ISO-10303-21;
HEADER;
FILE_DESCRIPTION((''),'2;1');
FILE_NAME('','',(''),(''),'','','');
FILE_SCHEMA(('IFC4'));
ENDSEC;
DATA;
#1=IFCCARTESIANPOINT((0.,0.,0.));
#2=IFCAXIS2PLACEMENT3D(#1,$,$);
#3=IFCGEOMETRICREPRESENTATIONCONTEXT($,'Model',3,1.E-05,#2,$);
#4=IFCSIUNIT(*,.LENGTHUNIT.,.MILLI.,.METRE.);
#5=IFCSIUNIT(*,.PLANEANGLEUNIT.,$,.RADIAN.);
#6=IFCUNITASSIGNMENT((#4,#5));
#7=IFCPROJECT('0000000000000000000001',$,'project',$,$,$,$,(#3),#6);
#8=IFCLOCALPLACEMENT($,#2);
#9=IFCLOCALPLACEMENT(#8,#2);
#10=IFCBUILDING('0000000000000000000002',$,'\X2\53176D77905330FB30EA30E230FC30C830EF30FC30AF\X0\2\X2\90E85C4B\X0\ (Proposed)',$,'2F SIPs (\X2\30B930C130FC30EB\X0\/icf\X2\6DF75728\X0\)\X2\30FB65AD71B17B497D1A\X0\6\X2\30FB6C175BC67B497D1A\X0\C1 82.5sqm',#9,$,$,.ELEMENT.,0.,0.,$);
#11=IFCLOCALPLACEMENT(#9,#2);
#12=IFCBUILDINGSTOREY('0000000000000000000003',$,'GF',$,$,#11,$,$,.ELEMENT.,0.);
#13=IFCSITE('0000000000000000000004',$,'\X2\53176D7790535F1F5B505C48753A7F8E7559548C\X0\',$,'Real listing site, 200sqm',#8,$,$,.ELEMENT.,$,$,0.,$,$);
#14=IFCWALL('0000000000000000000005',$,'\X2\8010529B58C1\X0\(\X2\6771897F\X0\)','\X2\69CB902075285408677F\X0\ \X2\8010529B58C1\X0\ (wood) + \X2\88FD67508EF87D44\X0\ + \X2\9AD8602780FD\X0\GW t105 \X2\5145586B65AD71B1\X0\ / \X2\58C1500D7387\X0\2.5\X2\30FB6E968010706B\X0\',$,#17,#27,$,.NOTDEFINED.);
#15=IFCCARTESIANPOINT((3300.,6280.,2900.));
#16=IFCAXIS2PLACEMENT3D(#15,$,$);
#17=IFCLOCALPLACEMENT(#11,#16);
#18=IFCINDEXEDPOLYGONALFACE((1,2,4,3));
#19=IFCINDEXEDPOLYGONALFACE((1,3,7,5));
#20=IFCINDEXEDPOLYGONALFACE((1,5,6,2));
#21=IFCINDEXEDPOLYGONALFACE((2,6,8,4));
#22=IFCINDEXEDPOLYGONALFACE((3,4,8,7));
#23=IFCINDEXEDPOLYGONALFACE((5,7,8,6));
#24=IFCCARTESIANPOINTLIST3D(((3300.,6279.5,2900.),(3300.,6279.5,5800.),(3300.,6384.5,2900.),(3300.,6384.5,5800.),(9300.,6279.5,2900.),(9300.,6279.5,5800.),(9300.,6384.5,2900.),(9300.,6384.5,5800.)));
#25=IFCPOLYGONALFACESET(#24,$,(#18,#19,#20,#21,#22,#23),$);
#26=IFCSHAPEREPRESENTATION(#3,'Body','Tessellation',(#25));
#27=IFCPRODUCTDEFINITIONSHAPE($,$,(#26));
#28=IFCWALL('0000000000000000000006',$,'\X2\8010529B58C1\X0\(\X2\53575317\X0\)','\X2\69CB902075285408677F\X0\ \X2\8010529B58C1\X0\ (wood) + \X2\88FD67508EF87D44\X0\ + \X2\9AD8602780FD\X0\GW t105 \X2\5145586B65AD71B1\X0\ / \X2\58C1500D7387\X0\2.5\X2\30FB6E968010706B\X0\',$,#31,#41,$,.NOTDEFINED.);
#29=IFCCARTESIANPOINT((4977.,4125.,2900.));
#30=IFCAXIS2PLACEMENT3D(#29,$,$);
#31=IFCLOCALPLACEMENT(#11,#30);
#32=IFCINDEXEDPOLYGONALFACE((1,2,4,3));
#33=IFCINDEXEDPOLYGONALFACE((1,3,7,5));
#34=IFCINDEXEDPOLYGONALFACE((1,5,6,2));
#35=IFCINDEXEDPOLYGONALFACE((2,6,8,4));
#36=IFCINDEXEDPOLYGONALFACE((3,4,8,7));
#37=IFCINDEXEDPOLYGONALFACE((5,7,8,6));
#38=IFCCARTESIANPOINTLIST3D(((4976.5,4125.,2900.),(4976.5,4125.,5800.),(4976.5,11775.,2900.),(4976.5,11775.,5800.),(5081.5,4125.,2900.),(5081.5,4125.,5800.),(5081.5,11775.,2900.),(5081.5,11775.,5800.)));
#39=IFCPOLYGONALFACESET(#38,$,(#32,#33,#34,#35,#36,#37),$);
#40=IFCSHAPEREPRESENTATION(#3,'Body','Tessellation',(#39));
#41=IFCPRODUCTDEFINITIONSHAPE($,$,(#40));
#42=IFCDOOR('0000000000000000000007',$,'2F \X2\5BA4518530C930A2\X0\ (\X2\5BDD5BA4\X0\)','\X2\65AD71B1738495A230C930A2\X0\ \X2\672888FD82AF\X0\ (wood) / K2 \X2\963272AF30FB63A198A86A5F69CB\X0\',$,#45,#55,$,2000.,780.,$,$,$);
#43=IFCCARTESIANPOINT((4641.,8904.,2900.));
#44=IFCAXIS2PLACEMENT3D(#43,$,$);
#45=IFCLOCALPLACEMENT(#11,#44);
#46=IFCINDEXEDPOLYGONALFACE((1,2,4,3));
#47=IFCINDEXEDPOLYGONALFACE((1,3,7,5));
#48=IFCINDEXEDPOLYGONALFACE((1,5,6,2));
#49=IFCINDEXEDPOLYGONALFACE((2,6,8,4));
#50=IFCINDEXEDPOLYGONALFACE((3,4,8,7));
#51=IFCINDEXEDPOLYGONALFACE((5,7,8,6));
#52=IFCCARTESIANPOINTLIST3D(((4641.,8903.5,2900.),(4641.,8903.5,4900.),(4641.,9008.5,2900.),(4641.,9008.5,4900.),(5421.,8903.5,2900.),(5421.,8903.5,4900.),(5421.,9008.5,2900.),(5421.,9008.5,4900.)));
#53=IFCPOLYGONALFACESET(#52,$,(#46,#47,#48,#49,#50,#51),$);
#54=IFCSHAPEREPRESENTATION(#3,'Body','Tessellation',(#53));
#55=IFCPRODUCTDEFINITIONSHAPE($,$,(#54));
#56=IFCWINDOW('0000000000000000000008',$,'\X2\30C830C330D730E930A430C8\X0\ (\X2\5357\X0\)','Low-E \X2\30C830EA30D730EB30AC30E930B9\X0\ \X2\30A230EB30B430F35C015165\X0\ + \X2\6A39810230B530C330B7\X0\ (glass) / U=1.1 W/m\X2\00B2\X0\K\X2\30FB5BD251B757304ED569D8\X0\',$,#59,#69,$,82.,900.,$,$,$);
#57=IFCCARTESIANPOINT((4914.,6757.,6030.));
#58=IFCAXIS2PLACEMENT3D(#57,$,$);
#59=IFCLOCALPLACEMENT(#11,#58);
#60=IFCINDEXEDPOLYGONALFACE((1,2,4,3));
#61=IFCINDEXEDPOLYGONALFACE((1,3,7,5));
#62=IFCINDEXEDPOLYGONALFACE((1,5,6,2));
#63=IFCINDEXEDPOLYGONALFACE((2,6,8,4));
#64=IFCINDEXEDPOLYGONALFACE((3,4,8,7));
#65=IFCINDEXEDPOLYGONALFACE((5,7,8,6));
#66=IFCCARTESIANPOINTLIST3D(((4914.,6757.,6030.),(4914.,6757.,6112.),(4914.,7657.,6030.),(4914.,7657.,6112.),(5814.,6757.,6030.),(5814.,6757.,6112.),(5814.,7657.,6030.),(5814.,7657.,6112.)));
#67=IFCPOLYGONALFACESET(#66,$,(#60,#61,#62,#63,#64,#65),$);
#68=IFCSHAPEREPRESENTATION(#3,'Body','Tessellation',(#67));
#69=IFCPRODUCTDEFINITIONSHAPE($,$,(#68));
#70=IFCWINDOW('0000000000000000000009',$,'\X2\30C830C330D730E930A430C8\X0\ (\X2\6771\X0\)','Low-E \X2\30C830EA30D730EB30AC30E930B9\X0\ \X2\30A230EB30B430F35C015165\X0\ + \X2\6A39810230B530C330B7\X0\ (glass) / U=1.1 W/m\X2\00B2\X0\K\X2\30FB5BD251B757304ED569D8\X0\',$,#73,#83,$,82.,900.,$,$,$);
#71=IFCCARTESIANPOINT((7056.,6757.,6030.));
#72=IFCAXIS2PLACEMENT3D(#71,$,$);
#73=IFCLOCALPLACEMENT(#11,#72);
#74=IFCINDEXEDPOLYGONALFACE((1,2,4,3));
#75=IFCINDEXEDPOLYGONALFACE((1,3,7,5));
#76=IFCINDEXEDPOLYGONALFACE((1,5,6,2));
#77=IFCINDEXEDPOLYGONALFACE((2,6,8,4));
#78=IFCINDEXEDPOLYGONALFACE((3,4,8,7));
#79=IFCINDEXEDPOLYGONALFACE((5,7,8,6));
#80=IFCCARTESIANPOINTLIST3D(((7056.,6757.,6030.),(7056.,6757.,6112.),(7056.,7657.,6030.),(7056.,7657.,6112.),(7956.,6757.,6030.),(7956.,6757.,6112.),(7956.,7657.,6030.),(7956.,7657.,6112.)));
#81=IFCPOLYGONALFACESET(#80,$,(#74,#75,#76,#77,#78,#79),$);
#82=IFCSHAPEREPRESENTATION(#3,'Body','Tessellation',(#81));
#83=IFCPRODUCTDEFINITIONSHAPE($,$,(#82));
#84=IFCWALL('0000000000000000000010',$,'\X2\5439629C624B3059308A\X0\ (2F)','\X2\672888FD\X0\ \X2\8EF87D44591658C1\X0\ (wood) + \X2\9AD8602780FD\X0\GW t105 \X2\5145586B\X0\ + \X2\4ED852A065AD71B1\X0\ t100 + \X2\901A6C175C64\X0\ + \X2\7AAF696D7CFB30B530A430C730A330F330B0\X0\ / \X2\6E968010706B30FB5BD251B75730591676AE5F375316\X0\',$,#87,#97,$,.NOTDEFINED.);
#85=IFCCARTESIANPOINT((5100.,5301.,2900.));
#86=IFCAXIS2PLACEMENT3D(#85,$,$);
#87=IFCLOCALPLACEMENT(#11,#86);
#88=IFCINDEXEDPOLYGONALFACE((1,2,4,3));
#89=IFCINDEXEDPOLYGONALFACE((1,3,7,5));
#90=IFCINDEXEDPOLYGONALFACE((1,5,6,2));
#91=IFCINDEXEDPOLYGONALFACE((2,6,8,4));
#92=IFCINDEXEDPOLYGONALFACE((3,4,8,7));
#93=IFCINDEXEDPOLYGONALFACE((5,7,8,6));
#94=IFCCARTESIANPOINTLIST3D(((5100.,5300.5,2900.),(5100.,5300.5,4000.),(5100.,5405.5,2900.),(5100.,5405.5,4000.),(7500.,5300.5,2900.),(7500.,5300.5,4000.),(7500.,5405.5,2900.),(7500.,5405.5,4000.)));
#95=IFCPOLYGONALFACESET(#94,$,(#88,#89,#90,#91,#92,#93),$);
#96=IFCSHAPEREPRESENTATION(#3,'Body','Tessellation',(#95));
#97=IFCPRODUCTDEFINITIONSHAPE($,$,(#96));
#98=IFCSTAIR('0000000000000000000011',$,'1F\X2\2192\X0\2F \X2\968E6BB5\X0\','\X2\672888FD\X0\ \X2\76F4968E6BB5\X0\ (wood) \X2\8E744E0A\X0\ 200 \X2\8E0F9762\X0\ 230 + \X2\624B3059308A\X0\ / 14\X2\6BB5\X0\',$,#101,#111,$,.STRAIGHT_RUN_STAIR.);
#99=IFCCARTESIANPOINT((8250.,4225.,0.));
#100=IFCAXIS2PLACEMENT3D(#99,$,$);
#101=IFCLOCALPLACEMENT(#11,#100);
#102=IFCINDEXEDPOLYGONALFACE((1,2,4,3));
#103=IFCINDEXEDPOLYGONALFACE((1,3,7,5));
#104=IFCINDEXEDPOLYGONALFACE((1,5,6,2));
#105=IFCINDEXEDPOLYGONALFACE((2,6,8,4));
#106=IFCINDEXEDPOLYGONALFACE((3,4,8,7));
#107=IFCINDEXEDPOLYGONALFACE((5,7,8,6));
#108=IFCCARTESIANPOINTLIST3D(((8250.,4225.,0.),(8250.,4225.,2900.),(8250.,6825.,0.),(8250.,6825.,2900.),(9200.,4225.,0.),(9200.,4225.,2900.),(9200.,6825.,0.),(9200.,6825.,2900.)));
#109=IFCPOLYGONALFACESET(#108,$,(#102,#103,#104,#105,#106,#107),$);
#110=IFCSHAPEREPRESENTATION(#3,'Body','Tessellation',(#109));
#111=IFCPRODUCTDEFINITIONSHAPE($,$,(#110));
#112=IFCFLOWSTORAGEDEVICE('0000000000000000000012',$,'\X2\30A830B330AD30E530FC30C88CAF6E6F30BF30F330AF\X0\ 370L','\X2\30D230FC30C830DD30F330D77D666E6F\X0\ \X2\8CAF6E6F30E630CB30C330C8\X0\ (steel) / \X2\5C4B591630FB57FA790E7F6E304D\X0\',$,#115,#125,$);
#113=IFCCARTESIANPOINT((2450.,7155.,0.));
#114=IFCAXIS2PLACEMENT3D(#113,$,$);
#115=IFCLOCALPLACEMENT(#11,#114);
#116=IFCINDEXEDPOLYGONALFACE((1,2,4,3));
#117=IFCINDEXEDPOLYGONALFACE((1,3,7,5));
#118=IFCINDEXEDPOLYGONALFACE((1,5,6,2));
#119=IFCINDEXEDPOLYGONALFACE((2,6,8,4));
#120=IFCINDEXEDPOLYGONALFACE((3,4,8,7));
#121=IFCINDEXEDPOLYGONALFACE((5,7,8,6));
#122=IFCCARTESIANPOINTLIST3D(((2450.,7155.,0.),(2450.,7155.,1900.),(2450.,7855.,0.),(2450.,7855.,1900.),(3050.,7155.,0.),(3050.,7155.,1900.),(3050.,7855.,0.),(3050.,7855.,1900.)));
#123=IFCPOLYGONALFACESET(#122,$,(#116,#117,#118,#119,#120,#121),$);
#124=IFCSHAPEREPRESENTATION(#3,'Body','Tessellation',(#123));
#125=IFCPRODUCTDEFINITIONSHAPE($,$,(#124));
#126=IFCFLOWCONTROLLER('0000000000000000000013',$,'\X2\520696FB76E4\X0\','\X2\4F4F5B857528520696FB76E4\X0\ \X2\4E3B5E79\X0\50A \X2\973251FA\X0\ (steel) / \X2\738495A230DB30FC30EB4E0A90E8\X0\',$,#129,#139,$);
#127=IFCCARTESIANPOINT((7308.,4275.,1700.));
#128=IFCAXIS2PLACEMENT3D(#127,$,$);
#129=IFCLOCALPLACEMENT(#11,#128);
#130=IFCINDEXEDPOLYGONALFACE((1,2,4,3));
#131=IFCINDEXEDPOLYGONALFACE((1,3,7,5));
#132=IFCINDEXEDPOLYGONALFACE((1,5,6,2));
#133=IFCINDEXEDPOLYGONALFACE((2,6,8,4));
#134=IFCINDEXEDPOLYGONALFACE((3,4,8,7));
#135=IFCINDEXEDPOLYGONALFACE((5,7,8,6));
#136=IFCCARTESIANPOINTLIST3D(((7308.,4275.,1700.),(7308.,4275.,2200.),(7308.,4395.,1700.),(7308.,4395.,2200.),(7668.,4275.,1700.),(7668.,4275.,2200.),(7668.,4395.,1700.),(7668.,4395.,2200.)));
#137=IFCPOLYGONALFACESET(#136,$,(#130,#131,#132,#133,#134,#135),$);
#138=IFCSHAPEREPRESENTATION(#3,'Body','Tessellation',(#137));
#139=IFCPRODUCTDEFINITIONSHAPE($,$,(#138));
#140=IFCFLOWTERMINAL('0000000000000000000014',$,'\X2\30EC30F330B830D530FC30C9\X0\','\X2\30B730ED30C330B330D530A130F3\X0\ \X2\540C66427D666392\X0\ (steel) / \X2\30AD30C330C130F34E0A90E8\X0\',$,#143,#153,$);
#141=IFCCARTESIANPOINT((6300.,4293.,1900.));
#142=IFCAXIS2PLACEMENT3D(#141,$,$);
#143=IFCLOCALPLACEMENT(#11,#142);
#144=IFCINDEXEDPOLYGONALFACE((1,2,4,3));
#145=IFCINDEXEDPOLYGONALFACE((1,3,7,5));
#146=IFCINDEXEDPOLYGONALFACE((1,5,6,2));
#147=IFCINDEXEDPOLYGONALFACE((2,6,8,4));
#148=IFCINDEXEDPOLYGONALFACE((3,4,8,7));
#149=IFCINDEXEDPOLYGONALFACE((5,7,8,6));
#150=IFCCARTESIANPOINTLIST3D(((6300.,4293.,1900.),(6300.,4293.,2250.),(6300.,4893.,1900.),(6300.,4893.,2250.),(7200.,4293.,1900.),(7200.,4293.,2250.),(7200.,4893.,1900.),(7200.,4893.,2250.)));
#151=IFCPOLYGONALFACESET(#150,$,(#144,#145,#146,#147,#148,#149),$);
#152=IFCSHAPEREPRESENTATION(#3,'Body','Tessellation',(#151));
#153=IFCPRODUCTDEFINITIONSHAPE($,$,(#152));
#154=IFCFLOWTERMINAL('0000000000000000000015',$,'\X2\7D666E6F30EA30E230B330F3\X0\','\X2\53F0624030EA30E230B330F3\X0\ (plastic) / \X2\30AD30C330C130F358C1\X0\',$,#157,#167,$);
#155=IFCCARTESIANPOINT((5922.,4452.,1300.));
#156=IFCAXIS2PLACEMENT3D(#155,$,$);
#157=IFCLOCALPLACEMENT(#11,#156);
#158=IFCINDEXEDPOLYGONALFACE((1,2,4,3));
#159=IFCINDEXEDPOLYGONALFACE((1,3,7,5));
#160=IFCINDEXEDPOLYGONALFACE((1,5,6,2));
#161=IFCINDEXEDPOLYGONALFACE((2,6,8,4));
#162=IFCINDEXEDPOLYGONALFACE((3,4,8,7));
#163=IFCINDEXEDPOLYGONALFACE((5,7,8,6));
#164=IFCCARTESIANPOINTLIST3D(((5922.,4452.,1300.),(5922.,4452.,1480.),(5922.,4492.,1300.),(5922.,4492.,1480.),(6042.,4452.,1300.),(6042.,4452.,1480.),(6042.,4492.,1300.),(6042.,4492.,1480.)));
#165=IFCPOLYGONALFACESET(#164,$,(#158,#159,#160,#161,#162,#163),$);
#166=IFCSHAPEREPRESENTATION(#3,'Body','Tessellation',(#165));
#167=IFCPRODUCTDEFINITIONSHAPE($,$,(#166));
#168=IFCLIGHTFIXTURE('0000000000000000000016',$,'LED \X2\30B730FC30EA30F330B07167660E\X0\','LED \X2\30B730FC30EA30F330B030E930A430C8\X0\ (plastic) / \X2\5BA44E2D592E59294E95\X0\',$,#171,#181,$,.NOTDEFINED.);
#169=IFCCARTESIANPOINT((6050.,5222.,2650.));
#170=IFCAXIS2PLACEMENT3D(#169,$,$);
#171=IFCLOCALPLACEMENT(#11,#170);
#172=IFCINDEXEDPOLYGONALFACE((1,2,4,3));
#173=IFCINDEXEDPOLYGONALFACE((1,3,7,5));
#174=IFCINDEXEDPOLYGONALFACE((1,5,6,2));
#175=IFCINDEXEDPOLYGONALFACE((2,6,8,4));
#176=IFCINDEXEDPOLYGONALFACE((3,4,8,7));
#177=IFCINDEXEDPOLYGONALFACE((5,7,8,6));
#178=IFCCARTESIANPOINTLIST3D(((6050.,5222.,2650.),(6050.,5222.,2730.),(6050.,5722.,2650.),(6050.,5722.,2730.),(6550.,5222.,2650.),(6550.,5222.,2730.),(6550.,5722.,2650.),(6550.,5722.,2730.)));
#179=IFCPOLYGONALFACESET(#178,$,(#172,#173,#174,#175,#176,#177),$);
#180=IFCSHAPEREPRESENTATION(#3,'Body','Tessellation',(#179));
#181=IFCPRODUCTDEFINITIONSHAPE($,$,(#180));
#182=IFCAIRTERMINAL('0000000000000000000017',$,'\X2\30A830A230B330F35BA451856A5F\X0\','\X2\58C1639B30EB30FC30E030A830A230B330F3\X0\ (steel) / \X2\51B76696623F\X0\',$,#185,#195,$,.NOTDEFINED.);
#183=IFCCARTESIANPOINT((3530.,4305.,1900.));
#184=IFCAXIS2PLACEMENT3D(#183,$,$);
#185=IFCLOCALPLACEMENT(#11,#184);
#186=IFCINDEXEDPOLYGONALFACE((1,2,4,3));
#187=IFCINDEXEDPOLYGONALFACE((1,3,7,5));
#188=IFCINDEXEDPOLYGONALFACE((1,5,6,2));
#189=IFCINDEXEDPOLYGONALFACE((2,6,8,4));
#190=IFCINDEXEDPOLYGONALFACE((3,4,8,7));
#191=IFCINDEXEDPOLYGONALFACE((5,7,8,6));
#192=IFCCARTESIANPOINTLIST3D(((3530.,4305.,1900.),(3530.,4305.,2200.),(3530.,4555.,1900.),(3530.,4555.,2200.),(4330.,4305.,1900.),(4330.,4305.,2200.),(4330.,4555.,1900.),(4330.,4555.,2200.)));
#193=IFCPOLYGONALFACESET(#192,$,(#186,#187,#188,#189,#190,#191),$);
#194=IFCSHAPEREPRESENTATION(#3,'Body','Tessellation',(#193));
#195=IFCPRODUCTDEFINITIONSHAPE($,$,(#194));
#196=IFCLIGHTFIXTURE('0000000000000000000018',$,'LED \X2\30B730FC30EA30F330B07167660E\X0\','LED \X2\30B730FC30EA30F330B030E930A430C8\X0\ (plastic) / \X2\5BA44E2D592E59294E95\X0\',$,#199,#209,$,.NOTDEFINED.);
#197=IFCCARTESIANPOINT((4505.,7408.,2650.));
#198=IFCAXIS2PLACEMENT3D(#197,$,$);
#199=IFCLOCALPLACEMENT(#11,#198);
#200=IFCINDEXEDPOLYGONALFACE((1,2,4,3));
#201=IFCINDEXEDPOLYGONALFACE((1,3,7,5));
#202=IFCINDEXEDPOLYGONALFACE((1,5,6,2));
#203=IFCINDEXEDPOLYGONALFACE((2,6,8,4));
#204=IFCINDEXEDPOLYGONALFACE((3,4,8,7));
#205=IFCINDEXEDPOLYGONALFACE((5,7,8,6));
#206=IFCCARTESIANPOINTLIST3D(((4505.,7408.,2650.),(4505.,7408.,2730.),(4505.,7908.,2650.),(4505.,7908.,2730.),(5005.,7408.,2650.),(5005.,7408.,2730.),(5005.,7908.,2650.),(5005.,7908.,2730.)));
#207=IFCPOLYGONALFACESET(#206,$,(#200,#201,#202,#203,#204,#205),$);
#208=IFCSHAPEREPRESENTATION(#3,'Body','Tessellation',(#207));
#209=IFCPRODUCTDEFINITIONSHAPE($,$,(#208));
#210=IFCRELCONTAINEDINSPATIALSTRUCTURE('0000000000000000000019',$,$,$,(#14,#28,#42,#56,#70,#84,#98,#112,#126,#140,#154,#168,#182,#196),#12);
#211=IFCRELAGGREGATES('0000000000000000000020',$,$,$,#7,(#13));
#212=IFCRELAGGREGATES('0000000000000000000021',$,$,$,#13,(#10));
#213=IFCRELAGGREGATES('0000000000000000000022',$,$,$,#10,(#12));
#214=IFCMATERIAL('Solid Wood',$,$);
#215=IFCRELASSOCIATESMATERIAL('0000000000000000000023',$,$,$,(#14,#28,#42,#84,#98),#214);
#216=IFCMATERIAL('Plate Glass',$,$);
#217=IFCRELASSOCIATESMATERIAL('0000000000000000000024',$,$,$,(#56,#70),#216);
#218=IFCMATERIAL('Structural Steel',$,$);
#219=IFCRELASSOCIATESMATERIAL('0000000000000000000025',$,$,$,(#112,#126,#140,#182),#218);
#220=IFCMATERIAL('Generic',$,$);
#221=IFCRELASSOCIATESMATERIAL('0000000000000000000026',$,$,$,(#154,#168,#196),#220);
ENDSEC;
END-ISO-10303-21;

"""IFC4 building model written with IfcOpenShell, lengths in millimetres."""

from ifc_helpers import new_model, si_unit, frame, frame_2d, origin, place, context, project, spatial, rectangle, extrude, material, element, fill, save


model = new_model("IFC4")

# Units and contexts
model_context = context("Model", 3, precision=1e-05, world=origin())
ifc_project = project(units=[si_unit("LENGTHUNIT", "METRE", prefix="MILLI"), si_unit("PLANEANGLEUNIT", "RADIAN")], contexts=[model_context])

# Site, building, storey
site_placement = place(None, origin())
site = spatial("IfcSite", under=ifc_project, at=site_placement, Name="北海道弟子屈町美留和", ObjectType="Real listing site, 200sqm", CompositionType="ELEMENT", RefElevation=0.0)
building_placement = place(site_placement, origin())
building = spatial("IfcBuilding", under=site, at=building_placement, Name="北海道・リモートワーク2部屋 (Proposed)", ObjectType="2F SIPs (スチール/icf混在)・断熱等級6・気密等級C1 82.5sqm", CompositionType="ELEMENT", ElevationOfRefHeight=0.0, ElevationOfTerrain=0.0)
storey_placement = place(building_placement, origin())
storey = spatial("IfcBuildingStorey", under=building, at=storey_placement, Name="GF", CompositionType="ELEMENT", Elevation=0.0)

# Shared definitions
ifc_material_1 = material(Name="Solid Wood")

# Wall
wall_1_placement = place(storey_placement, frame((3300.0, 6280.0, 2900.0)))
element("IfcWall", 1, at=wall_1_placement, inside=storey, material=ifc_material_1, Name="耐力壁(東西)", Description="構造用合板 耐力壁 (wood) + 製材軸組 + 高性能GW t105 充填断熱 / 壁倍率2.5・準耐火", PredefinedType="NOTDEFINED", context=model_context, shape_type="SweptSolid", body=[
    extrude(rectangle(XDim=6000.0, YDim=105.0, at=frame_2d((3000.0, 52.0))), frame((3300.0, 6280.0, 2900.0)), (0.0, 0.0, 1.0), 2900.0),
])

# Wall, opening, door
wall_2_placement = place(storey_placement, frame((4977.0, 4125.0, 2900.0)))
wall_2 = element("IfcWall", 2, at=wall_2_placement, inside=storey, material=ifc_material_1, Name="耐力壁(南北)", Description="構造用合板 耐力壁 (wood) + 製材軸組 + 高性能GW t105 充填断熱 / 壁倍率2.5・準耐火", PredefinedType="NOTDEFINED", context=model_context, shape_type="SweptSolid", body=[
    extrude(rectangle(XDim=105.0, YDim=7650.0, at=frame_2d((52.0, 3825.0))), frame((4977.0, 4125.0, 2900.0)), (0.0, 0.0, 1.0), 2900.0),
])
opening_placement = place(storey_placement, frame((4641.0, 8904.0, 2900.0)))
opening = element("IfcOpeningElement", 3, at=opening_placement, cuts=wall_2, PredefinedType="NOTDEFINED", context=model_context, shape_type="SweptSolid", body=[
    extrude(rectangle(XDim=780.0, YDim=105.0, at=frame_2d((390.0, 52.0))), frame((4641.0, 8904.0, 2900.0)), (0.0, 0.0, 1.0), 2000.0),
])
door_placement = place(storey_placement, frame((4641.0, 8904.0, 2900.0)))
door = element("IfcDoor", 4, at=door_placement, inside=storey, material=ifc_material_1, Name="2F 室内ドア (寝室)", Description="断熱玄関ドア 木製芯 (wood) / K2 防犯・採風機構", OverallHeight=2000.0, OverallWidth=780.0, context=model_context, shape_type="SweptSolid", body=[
    extrude(rectangle(XDim=780.0, YDim=105.0, at=frame_2d((390.0, 52.0))), frame((4641.0, 8904.0, 2900.0)), (0.0, 0.0, 1.0), 2000.0),
])
fill(opening, door)

# Windows
ifc_material_2 = material(Name="Plate Glass")
window_1_placement = place(storey_placement, frame((4914.0, 6757.0, 6030.0)))
element("IfcWindow", 5, at=window_1_placement, inside=storey, material=ifc_material_2, Name="トップライト (南)", Description="Low-E トリプルガラス アルゴン封入 + 樹脂サッシ (glass) / U=1.1 W/m²K・寒冷地仕様", OverallHeight=82.0, OverallWidth=900.0, context=model_context, shape_type="SweptSolid", body=[
    extrude(rectangle(XDim=900.0, YDim=900.0, at=frame_2d((450.0, 450.0))), frame((4914.0, 6757.0, 6030.0)), (0.0, 0.0, 1.0), 82.0),
])
window_2_placement = place(storey_placement, frame((7056.0, 6757.0, 6030.0)))
element("IfcWindow", 6, at=window_2_placement, inside=storey, material=ifc_material_2, Name="トップライト (東)", Description="Low-E トリプルガラス アルゴン封入 + 樹脂サッシ (glass) / U=1.1 W/m²K・寒冷地仕様", OverallHeight=82.0, OverallWidth=900.0, context=model_context, shape_type="SweptSolid", body=[
    extrude(rectangle(XDim=900.0, YDim=900.0, at=frame_2d((450.0, 450.0))), frame((7056.0, 6757.0, 6030.0)), (0.0, 0.0, 1.0), 82.0),
])

# Wall
wall_3_placement = place(storey_placement, frame((5100.0, 5301.0, 2900.0)))
element("IfcWall", 7, at=wall_3_placement, inside=storey, material=ifc_material_1, Name="吹抜手すり (2F)", Description="木製 軸組外壁 (wood) + 高性能GW t105 充填 + 付加断熱 t100 + 通気層 + 窯業系サイディング / 準耐火・寒冷地外皮強化", PredefinedType="NOTDEFINED", context=model_context, shape_type="SweptSolid", body=[
    extrude(rectangle(XDim=2400.0, YDim=105.0, at=frame_2d((1200.0, 52.0))), frame((5100.0, 5301.0, 2900.0)), (0.0, 0.0, 1.0), 1100.0),
])

# Stair
stair_placement = place(storey_placement, frame((8250.0, 4225.0, 0.0)))
element("IfcStair", 8, at=stair_placement, inside=storey, material=ifc_material_1, Name="1F→2F 階段", Description="木製 直階段 (wood) 蹴上 200 踏面 230 + 手すり / 14段", PredefinedType="STRAIGHT_RUN_STAIR", context=model_context, shape_type="SweptSolid", body=[
    extrude(rectangle(XDim=950.0, YDim=2600.0, at=frame_2d((475.0, 1300.0))), frame((8250.0, 4225.0, 0.0)), (0.0, 0.0, 1.0), 2900.0),
])

# Flow storage device
ifc_material_3 = material(Name="Structural Steel")
flow_storage_device_placement = place(storey_placement, frame((2450.0, 7155.0, 0.0)))
element("IfcFlowStorageDevice", 9, at=flow_storage_device_placement, inside=storey, material=ifc_material_3, Name="エコキュート貯湯タンク 370L", Description="ヒートポンプ給湯 貯湯ユニット (steel) / 屋外・基礎置き", context=model_context, shape_type="SweptSolid", body=[
    extrude(rectangle(XDim=600.0, YDim=700.0, at=frame_2d((300.0, 350.0))), frame((2450.0, 7155.0, 0.0)), (0.0, 0.0, 1.0), 1900.0),
])

# Flow controller
flow_controller_placement = place(storey_placement, frame((7308.0, 4275.0, 1700.0)))
element("IfcFlowController", 10, at=flow_controller_placement, inside=storey, material=ifc_material_3, Name="分電盤", Description="住宅用分電盤 主幹50A 露出 (steel) / 玄関ホール上部", context=model_context, shape_type="SweptSolid", body=[
    extrude(rectangle(XDim=360.0, YDim=120.0, at=frame_2d((180.0, 60.0))), frame((7308.0, 4275.0, 1700.0)), (0.0, 0.0, 1.0), 500.0),
])

# Flow terminals
flow_terminal_1_placement = place(storey_placement, frame((6300.0, 4293.0, 1900.0)))
element("IfcFlowTerminal", 11, at=flow_terminal_1_placement, inside=storey, material=ifc_material_3, Name="レンジフード", Description="シロッコファン 同時給排 (steel) / キッチン上部", context=model_context, shape_type="SweptSolid", body=[
    extrude(rectangle(XDim=900.0, YDim=600.0, at=frame_2d((450.0, 300.0))), frame((6300.0, 4293.0, 1900.0)), (0.0, 0.0, 1.0), 350.0),
])
ifc_material_4 = material(Name="Generic")
flow_terminal_2_placement = place(storey_placement, frame((5922.0, 4452.0, 1300.0)))
element("IfcFlowTerminal", 12, at=flow_terminal_2_placement, inside=storey, material=ifc_material_4, Name="給湯リモコン", Description="台所リモコン (plastic) / キッチン壁", context=model_context, shape_type="SweptSolid", body=[
    extrude(rectangle(XDim=120.0, YDim=40.0, at=frame_2d((60.0, 20.0))), frame((5922.0, 4452.0, 1300.0)), (0.0, 0.0, 1.0), 180.0),
])

# Light fixture
light_fixture_1_placement = place(storey_placement, frame((6050.0, 5222.0, 2650.0)))
element("IfcLightFixture", 13, at=light_fixture_1_placement, inside=storey, material=ifc_material_4, Name="LED シーリング照明", Description="LED シーリングライト (plastic) / 室中央天井", PredefinedType="NOTDEFINED", context=model_context, shape_type="SweptSolid", body=[
    extrude(rectangle(XDim=500.0, YDim=500.0, at=frame_2d((250.0, 250.0))), frame((6050.0, 5222.0, 2650.0)), (0.0, 0.0, 1.0), 80.0),
])

# Air terminal
air_terminal_1_placement = place(storey_placement, frame((3530.0, 4305.0, 1900.0)))
element("IfcAirTerminal", 14, at=air_terminal_1_placement, inside=storey, material=ifc_material_3, Name="エアコン室内機", Description="壁掛ルームエアコン (steel) / 冷暖房", PredefinedType="NOTDEFINED", context=model_context, shape_type="SweptSolid", body=[
    extrude(rectangle(XDim=800.0, YDim=250.0, at=frame_2d((400.0, 125.0))), frame((3530.0, 4305.0, 1900.0)), (0.0, 0.0, 1.0), 300.0),
])

# Light fixture
light_fixture_2_placement = place(storey_placement, frame((4505.0, 7408.0, 2650.0)))
element("IfcLightFixture", 15, at=light_fixture_2_placement, inside=storey, material=ifc_material_4, Name="LED シーリング照明", Description="LED シーリングライト (plastic) / 室中央天井", PredefinedType="NOTDEFINED", context=model_context, shape_type="SweptSolid", body=[
    extrude(rectangle(XDim=500.0, YDim=500.0, at=frame_2d((250.0, 250.0))), frame((4505.0, 7408.0, 2650.0)), (0.0, 0.0, 1.0), 80.0),
])

save(model, "model.ifc")
